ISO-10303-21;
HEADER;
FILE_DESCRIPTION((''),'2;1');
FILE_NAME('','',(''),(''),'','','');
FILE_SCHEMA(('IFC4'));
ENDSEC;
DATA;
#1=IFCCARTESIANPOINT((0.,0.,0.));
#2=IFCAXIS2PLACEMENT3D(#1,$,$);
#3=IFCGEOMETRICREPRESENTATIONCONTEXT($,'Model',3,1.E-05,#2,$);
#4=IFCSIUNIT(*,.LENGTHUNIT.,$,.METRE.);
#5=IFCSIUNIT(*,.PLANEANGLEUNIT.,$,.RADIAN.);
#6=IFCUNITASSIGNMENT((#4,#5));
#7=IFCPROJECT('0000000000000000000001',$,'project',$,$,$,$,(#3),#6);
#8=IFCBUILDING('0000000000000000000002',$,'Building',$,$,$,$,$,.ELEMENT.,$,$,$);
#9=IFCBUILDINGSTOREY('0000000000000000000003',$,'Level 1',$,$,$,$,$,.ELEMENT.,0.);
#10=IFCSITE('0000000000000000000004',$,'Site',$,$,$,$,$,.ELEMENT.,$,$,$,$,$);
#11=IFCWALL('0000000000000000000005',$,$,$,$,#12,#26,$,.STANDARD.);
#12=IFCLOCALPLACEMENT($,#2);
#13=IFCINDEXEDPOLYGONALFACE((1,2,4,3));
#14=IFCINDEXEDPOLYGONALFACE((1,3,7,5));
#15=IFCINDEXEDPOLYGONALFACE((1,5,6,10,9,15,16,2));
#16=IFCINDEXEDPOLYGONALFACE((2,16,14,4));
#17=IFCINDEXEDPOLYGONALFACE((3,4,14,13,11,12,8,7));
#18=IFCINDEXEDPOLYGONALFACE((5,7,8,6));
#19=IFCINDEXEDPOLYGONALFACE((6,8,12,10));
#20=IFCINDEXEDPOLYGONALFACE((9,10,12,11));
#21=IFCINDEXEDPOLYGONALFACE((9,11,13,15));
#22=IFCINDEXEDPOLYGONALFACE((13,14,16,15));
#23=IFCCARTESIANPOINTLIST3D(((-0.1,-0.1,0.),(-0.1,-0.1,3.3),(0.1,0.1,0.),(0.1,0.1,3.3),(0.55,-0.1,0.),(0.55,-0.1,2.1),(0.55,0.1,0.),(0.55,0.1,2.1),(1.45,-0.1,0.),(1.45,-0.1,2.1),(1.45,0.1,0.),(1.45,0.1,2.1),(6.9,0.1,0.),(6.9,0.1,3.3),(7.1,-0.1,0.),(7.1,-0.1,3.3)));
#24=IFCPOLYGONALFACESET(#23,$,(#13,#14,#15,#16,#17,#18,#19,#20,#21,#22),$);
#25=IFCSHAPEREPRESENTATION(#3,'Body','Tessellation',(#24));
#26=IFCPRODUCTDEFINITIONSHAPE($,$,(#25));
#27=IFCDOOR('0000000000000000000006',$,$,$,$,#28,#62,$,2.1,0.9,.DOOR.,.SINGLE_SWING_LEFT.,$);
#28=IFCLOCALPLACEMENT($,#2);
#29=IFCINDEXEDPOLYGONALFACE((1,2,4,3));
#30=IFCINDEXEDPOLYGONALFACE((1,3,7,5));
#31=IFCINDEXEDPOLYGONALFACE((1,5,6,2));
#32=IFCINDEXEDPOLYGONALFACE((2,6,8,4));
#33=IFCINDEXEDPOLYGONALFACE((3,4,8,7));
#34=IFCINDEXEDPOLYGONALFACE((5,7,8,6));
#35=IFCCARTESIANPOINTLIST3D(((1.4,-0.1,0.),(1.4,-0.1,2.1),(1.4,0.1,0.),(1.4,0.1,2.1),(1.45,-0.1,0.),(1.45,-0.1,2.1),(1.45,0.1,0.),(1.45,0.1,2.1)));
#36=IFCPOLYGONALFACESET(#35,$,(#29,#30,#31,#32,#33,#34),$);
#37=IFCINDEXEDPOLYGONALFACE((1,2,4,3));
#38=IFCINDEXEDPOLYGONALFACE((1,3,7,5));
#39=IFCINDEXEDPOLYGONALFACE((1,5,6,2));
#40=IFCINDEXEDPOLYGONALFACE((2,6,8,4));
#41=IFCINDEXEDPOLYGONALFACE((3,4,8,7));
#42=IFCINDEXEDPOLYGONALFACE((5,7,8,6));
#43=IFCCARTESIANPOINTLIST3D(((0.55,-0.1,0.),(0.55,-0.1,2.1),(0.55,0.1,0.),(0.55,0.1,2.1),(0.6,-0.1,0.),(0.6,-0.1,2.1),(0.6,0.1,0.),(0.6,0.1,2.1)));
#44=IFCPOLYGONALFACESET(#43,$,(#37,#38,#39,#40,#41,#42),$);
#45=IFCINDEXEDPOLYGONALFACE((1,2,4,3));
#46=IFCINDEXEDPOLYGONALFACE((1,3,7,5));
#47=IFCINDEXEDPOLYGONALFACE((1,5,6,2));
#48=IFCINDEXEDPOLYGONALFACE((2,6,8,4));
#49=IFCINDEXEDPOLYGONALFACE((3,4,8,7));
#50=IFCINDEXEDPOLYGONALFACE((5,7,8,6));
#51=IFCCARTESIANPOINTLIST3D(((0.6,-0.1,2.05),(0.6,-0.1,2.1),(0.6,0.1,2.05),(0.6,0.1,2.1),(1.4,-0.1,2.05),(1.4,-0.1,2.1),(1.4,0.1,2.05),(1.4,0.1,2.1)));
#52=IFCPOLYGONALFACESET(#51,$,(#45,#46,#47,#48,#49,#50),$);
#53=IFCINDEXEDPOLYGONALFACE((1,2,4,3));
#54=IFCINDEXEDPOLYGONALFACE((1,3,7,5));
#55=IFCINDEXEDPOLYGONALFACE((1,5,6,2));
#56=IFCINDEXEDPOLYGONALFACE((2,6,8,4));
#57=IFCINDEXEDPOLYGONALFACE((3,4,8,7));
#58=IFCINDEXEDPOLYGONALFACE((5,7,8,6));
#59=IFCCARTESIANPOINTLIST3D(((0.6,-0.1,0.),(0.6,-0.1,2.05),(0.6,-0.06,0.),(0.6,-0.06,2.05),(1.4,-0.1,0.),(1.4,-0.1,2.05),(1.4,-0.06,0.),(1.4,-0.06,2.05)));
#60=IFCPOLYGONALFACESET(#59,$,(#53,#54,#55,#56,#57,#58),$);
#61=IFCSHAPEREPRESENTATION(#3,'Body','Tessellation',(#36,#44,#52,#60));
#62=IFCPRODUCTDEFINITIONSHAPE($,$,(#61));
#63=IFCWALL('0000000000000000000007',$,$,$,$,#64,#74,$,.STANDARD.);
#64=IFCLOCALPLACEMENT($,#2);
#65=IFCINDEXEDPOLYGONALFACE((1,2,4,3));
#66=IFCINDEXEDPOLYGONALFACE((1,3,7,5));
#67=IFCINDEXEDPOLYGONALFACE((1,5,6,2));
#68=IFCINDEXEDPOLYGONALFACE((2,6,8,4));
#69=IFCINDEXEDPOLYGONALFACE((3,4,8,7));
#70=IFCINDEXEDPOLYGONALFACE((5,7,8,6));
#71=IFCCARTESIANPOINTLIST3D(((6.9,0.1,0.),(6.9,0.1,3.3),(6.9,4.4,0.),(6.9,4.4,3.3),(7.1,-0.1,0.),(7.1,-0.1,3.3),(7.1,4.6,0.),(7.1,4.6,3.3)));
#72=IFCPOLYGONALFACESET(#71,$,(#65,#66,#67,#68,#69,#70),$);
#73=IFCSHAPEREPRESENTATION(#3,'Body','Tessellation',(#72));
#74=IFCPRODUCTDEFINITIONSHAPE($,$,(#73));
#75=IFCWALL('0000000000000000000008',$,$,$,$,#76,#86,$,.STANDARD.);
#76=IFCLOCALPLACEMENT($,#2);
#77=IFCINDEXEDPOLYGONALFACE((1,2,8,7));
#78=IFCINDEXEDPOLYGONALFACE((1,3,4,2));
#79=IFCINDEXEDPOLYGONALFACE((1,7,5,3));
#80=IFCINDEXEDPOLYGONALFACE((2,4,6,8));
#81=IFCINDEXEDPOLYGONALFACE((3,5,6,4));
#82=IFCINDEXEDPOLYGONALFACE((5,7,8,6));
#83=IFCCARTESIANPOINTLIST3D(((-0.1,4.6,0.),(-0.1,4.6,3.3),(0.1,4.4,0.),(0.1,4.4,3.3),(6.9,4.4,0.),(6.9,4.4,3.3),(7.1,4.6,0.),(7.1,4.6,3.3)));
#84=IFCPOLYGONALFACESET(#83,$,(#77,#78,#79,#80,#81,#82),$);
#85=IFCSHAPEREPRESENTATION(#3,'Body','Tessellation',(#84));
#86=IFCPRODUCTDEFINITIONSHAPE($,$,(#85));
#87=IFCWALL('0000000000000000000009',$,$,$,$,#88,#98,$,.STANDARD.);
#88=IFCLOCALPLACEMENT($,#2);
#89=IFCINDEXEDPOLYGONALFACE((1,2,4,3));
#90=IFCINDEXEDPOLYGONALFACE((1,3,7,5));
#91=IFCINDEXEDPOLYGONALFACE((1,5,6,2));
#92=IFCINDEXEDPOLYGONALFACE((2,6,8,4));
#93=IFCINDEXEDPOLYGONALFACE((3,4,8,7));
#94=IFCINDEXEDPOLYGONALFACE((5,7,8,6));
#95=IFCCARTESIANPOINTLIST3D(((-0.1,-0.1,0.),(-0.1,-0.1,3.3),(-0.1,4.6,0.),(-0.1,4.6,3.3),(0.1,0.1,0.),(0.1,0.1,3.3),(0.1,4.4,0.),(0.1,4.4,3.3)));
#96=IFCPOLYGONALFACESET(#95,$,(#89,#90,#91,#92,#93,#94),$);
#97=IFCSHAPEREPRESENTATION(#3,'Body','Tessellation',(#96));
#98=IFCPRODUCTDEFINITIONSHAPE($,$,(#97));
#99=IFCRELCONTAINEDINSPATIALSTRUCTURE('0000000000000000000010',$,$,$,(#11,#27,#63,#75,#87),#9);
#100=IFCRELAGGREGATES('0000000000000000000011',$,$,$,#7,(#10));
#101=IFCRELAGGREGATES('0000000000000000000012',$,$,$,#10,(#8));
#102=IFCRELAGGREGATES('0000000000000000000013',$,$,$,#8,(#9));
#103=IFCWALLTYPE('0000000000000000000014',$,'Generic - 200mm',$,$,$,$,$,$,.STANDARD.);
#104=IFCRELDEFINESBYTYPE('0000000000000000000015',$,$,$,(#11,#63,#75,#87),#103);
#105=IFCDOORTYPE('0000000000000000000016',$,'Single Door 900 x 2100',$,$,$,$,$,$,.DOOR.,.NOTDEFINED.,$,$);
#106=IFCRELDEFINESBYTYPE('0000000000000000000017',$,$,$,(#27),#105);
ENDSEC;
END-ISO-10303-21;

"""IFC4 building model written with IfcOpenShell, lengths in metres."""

from ifc_helpers import new_model, si_unit, frame, frame_2d, origin, origin_with_axes, origin_2d, place, context, project, spatial, polyline, rectangle, outline, extrude, type_object, element, fill, save


model = new_model("IFC4")

# Units and contexts
model_context = context("Model", 3, precision=1e-05, world=origin())
ifc_project = project(units=[si_unit("LENGTHUNIT", "METRE"), si_unit("PLANEANGLEUNIT", "RADIAN")], contexts=[model_context])

# Site, building, storey
site = spatial("IfcSite", under=ifc_project, Name="Site", CompositionType="ELEMENT")
building = spatial("IfcBuilding", under=site, Name="Building", CompositionType="ELEMENT")
storey = spatial("IfcBuildingStorey", under=building, Name="Level 1", CompositionType="ELEMENT", Elevation=0.0)

# Wall, opening, door
wall_type = type_object("IfcWallType", Name="Generic - 200mm", PredefinedType="STANDARD")
wall_1_placement = place(None, frame((7.0, 0.0, 0.0), z_axis=(0.0, 0.0, 1.0), x_axis=(-1.0, 0.0, 0.0)))
wall_1 = element("IfcWall", 1, at=wall_1_placement, inside=storey, type_object=wall_type, PredefinedType="STANDARD", context=model_context, shape_type="SweptSolid", body=[
    extrude(outline(polyline([(0.1, -0.1), (6.9, -0.1), (7.1, 0.1), (-0.1, 0.1), (0.1, -0.1)])), origin(), (0.0, 0.0, 1.0), 3.3),
])
opening_placement = place(wall_1_placement, frame((6.0, 0.0, 0.0), z_axis=(0.0, 0.0, 1.0), x_axis=(1.0, 0.0, 0.0)))
opening = element("IfcOpeningElement", 2, at=opening_placement, cuts=wall_1, PredefinedType="OPENING", context=model_context, shape_type="SweptSolid", body=[
    extrude(rectangle(XDim=0.9, YDim=0.202, at=origin_2d()), origin(), (0.0, 0.0, 1.0), 2.1),
])
door_type = type_object("IfcDoorType", Name="Single Door 900 x 2100", OperationType="NOTDEFINED", PredefinedType="DOOR")
door_placement = place(opening_placement, origin_with_axes())
door = element("IfcDoor", 3, at=door_placement, inside=storey, type_object=door_type, OperationType="SINGLE_SWING_LEFT", OverallHeight=2.1, OverallWidth=0.9, PredefinedType="DOOR", context=model_context, shape_type="SweptSolid", body=[
    extrude(rectangle(XDim=0.05, YDim=0.2, at=frame_2d((-0.425, 0.0))), origin(), (0.0, 0.0, 1.0), 2.1),
    extrude(rectangle(XDim=0.05, YDim=0.2, at=frame_2d((0.425, 0.0))), origin(), (0.0, 0.0, 1.0), 2.1),
    extrude(rectangle(XDim=0.8, YDim=0.2, at=origin_2d()), frame((0.0, 0.0, 2.05)), (0.0, 0.0, 1.0), 0.05),
    extrude(rectangle(XDim=0.8, YDim=0.04, at=frame_2d((0.0, 0.08))), origin(), (0.0, 0.0, 1.0), 2.05),
])
fill(opening, door)

# Walls
wall_2_placement = place(None, frame((7.0, 4.5, 0.0), z_axis=(0.0, 0.0, 1.0), x_axis=(0.0, -1.0, 0.0)))
element("IfcWall", 4, at=wall_2_placement, inside=storey, type_object=wall_type, PredefinedType="STANDARD", context=model_context, shape_type="SweptSolid", body=[
    extrude(outline(polyline([(0.1, -0.1), (4.4, -0.1), (4.6, 0.1), (-0.1, 0.1), (0.1, -0.1)])), origin(), (0.0, 0.0, 1.0), 3.3),
])
wall_3_placement = place(None, frame((0.0, 4.5, 0.0), z_axis=(0.0, 0.0, 1.0), x_axis=(1.0, 0.0, 0.0)))
element("IfcWall", 5, at=wall_3_placement, inside=storey, type_object=wall_type, PredefinedType="STANDARD", context=model_context, shape_type="SweptSolid", body=[
    extrude(outline(polyline([(0.1, -0.1), (6.9, -0.1), (7.1, 0.1), (-0.1, 0.1), (0.1, -0.1)])), origin(), (0.0, 0.0, 1.0), 3.3),
])
wall_4_placement = place(None, frame((0.0, 0.0, 0.0), z_axis=(0.0, 0.0, 1.0), x_axis=(0.0, 1.0, 0.0)))
element("IfcWall", 6, at=wall_4_placement, inside=storey, type_object=wall_type, PredefinedType="STANDARD", context=model_context, shape_type="SweptSolid", body=[
    extrude(outline(polyline([(0.1, -0.1), (4.4, -0.1), (4.6, 0.1), (-0.1, 0.1), (0.1, -0.1)])), origin(), (0.0, 0.0, 1.0), 3.3),
])

save(model, "model.ifc")
